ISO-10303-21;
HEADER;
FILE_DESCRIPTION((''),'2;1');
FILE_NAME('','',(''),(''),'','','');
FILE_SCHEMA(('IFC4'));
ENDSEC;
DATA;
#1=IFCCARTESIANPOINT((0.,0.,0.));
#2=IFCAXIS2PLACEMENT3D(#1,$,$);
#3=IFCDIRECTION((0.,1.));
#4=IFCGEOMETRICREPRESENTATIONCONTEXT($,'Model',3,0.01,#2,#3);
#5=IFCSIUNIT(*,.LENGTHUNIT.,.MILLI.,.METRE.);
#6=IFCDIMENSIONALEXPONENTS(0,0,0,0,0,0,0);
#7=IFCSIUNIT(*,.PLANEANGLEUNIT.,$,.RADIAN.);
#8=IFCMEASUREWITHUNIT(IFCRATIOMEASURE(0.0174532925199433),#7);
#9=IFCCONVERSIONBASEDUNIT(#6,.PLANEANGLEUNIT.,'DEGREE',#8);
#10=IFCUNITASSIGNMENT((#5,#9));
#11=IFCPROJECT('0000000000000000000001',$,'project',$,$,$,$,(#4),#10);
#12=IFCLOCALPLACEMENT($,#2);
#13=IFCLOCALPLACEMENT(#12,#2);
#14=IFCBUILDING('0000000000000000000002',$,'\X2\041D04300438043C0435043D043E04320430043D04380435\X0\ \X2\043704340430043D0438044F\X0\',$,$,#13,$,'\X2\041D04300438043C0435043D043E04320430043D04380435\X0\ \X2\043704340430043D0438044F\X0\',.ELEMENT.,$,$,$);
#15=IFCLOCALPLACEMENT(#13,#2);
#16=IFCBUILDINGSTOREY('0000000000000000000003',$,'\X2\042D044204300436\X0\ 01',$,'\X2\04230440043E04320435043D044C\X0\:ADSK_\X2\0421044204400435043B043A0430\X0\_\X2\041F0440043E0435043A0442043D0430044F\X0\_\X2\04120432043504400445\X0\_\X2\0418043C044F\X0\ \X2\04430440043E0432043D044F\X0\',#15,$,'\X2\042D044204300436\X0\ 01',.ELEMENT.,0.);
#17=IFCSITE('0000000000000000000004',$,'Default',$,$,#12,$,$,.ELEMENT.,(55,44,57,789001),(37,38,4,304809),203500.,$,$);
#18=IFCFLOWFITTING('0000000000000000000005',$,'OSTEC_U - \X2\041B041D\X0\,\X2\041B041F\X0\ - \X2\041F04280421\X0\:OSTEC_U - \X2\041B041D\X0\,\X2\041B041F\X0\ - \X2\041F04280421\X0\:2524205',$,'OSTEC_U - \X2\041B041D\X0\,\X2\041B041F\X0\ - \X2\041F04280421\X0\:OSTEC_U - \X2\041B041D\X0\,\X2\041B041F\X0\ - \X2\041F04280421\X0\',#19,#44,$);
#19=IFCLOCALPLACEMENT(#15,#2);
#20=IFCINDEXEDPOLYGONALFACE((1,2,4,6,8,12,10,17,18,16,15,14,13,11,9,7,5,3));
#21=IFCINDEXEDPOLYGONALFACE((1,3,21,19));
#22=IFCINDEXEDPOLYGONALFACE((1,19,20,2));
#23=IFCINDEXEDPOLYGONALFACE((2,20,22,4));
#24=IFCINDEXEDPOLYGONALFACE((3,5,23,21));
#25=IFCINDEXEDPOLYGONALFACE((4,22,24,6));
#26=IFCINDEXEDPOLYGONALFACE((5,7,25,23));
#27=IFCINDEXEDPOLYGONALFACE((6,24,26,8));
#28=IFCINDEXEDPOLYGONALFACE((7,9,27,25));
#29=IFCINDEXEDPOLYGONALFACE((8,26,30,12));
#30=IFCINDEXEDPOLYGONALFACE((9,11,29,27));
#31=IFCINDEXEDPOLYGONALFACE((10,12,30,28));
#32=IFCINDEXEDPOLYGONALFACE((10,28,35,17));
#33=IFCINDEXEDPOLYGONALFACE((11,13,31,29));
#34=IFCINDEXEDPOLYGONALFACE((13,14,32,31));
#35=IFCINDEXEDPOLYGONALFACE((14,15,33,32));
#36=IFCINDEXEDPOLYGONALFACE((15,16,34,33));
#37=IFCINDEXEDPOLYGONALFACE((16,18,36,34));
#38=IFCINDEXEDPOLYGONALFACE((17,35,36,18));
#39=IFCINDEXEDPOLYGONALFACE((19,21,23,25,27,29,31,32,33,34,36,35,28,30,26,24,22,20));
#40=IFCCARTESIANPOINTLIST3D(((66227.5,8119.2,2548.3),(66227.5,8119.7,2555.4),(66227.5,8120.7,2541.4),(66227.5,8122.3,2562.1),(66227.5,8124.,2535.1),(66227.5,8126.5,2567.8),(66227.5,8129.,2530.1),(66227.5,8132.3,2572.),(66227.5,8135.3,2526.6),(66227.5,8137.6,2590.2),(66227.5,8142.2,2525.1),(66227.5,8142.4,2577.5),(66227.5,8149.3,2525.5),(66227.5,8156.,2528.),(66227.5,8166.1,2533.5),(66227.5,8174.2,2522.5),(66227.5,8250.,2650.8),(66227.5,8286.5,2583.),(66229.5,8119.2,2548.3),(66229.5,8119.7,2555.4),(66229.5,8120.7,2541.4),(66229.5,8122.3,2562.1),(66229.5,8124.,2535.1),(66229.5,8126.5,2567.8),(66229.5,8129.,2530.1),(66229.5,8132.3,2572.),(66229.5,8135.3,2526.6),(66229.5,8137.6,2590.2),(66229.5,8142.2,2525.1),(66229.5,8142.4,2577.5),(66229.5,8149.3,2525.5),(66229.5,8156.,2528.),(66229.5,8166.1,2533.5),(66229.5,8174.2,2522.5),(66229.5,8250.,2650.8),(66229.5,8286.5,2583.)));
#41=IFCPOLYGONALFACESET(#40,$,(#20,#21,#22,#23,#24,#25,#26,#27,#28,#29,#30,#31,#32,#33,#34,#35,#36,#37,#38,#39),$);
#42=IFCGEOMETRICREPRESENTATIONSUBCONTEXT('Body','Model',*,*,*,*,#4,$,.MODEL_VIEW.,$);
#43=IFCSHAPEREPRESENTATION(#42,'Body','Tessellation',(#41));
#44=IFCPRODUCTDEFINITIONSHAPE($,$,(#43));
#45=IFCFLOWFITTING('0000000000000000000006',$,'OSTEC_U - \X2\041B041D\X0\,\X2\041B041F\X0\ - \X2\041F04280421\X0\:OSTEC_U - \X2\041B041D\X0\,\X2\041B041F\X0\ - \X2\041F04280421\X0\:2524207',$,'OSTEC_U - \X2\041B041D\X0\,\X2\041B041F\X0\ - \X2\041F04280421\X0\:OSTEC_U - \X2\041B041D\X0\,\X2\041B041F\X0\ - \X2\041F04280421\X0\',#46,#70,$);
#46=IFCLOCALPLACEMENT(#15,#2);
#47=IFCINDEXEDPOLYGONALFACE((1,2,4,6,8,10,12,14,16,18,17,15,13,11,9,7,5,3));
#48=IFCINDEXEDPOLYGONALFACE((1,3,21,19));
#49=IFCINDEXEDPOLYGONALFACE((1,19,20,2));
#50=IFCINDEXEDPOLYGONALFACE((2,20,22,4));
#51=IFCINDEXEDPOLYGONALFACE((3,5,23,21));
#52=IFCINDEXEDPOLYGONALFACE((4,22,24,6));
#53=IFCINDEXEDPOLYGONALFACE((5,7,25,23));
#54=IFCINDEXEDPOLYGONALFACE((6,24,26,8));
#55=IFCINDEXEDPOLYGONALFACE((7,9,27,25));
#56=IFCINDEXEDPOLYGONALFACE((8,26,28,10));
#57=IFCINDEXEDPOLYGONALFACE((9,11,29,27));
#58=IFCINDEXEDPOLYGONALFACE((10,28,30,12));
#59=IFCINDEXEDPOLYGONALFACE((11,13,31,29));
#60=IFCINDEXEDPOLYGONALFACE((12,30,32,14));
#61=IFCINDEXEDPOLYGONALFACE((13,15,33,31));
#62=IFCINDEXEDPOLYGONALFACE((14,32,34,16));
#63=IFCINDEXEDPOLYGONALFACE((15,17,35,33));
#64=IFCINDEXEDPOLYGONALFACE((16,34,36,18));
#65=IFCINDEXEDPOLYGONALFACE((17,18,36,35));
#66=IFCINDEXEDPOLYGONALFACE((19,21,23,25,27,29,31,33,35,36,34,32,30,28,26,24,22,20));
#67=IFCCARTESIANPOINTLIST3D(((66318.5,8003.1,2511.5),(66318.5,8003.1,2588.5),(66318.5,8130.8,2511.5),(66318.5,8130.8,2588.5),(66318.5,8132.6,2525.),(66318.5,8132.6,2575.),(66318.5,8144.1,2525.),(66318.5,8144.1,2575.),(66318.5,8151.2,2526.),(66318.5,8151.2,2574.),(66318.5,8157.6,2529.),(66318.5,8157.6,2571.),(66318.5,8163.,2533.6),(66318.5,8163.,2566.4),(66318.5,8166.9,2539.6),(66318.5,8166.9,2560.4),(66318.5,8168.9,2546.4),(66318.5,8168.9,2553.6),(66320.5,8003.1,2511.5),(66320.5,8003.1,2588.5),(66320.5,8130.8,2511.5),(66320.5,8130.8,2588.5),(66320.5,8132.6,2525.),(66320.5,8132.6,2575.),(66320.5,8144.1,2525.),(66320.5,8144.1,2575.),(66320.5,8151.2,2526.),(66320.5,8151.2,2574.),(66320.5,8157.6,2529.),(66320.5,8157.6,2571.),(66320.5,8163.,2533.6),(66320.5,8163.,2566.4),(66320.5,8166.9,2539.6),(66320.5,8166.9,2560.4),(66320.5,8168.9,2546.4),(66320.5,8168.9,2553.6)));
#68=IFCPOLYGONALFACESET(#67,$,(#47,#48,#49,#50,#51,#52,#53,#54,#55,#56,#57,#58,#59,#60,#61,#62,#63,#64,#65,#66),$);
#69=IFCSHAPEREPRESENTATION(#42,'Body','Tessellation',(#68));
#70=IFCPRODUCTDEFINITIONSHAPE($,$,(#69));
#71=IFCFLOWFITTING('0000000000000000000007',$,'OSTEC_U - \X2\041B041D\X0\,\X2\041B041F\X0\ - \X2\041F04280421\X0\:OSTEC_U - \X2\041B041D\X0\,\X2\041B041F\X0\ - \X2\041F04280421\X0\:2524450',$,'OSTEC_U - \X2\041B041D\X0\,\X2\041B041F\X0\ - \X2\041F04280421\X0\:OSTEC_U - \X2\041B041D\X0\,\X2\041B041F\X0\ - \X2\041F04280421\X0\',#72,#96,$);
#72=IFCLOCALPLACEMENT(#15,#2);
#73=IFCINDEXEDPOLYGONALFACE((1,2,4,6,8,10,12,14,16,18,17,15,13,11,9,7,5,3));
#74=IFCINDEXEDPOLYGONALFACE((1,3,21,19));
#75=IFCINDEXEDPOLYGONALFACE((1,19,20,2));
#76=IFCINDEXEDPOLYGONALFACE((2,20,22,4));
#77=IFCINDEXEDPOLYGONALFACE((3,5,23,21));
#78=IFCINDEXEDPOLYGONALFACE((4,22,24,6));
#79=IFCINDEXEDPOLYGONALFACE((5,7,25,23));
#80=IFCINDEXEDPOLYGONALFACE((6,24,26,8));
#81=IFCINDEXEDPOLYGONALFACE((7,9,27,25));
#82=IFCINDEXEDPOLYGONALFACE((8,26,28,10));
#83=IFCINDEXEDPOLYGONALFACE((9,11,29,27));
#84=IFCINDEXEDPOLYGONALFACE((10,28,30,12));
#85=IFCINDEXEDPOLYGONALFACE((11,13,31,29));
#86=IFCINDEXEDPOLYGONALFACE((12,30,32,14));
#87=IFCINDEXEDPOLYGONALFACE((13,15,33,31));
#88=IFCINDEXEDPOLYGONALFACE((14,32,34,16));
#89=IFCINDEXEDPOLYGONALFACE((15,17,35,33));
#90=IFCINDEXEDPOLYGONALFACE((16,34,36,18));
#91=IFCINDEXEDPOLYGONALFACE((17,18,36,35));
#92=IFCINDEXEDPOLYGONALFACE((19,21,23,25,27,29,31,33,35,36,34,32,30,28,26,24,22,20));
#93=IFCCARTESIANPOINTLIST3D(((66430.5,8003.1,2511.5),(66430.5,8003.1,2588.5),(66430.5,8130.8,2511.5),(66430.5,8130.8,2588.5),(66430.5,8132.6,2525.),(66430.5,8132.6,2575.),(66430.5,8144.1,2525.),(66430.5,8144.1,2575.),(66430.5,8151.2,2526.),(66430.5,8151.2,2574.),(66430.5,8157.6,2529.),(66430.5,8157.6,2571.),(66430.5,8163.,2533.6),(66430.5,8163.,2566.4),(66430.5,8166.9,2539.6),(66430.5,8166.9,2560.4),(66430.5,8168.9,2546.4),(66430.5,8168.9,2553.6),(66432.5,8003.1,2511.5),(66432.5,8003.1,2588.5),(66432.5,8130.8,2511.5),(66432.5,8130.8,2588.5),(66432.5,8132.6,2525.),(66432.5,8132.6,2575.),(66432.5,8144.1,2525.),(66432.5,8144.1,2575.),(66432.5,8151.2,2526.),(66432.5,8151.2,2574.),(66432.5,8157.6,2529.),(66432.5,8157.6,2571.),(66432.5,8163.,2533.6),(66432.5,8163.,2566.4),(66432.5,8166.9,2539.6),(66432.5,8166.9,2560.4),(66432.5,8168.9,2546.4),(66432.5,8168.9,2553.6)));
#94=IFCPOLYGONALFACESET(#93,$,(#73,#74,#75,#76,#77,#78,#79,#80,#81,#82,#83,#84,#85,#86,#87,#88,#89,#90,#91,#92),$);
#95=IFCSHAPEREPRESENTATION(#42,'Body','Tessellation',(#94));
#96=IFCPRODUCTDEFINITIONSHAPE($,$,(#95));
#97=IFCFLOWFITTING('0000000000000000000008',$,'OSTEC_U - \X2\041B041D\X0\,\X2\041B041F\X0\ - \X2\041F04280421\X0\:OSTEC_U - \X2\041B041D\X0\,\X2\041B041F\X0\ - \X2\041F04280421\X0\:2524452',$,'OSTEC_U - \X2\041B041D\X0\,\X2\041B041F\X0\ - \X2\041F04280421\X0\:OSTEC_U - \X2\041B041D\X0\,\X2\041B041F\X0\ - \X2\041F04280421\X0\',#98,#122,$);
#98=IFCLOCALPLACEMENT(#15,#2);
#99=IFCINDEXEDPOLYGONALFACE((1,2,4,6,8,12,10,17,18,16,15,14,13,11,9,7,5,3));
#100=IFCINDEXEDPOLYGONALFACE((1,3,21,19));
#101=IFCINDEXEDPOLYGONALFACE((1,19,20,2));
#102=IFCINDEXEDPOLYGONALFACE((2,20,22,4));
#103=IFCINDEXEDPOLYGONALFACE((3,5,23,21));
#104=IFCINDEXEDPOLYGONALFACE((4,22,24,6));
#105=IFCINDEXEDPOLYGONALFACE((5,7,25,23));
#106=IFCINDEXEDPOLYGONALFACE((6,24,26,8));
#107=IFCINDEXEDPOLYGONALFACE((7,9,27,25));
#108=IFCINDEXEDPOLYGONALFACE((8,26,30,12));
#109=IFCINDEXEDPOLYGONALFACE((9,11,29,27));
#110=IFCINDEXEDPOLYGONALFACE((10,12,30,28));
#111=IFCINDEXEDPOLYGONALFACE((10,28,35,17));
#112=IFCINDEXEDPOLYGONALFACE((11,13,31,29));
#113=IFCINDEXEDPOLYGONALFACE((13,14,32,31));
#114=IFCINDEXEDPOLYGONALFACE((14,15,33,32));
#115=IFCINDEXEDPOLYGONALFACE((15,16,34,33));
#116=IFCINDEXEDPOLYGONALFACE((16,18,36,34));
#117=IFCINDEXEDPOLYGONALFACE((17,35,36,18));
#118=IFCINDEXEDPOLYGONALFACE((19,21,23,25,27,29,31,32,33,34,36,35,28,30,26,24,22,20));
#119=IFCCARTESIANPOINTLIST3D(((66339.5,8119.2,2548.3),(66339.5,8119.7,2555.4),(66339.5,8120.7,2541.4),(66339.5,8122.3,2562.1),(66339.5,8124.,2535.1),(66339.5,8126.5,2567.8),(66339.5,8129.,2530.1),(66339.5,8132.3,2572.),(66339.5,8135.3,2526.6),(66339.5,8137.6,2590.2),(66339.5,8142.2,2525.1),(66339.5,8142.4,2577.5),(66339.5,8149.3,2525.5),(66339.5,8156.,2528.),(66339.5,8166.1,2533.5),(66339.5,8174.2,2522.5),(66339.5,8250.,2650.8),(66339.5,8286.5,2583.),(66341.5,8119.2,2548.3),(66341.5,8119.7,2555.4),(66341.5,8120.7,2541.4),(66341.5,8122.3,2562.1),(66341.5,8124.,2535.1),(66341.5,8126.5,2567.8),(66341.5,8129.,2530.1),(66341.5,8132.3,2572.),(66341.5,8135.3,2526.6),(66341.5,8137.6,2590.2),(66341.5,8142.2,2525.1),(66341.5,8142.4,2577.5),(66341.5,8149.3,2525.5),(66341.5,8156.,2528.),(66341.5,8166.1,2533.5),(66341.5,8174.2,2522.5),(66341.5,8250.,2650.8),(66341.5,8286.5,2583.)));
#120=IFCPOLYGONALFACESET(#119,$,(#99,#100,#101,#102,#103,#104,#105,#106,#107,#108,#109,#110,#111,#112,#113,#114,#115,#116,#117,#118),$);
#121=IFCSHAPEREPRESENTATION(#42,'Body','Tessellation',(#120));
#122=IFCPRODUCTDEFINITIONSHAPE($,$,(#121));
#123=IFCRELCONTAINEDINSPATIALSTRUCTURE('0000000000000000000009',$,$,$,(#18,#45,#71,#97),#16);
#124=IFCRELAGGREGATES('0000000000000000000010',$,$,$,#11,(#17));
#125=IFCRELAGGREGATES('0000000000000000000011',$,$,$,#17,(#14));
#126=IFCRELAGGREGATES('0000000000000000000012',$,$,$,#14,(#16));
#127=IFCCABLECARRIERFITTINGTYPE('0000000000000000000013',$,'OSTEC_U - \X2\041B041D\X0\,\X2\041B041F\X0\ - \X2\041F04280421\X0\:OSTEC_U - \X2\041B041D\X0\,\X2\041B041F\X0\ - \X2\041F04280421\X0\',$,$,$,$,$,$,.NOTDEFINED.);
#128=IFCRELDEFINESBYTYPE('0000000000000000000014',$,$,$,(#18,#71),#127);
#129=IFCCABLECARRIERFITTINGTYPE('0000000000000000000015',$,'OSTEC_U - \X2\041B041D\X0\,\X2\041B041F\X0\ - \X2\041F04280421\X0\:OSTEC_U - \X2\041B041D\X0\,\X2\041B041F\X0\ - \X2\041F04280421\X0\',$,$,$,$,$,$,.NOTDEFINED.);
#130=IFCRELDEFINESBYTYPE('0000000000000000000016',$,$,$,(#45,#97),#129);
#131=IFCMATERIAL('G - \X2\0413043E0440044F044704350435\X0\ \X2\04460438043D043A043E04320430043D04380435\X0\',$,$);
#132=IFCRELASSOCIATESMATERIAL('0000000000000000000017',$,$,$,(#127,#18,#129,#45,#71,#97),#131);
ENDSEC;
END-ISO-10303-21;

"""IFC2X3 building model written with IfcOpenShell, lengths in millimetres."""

from ifc_helpers import new_model, entity, si_unit, converted_unit, direction, frame, frame_2d, origin, place, context, subcontext, project, spatial, polyline, circle_curve, parameter, trimmed, segment, composite_curve, outline, extrude, source, transform, mapped, material, type_object, type_shapes, element, save


model = new_model("IFC2X3")

# Units and contexts
model_context = context("Model", 3, precision=0.01, world=origin(), true_north=direction((0.0, 1.0)))
body_context = subcontext(model_context, "Body", "Model", "MODEL_VIEW")
ifc_project = project(units=[si_unit("LENGTHUNIT", "METRE", prefix="MILLI"), converted_unit("PLANEANGLEUNIT", "DEGREE", entity("IfcRatioMeasure", 0.0174532925199433), si_unit("PLANEANGLEUNIT", "RADIAN"), dimensions=[0, 0, 0, 0, 0, 0, 0])], contexts=[model_context])

# Site, building, storey
site_placement = place(None, origin())
site = spatial("IfcSite", under=ifc_project, at=site_placement, Name="Default", CompositionType="ELEMENT", RefLatitude=(55, 44, 57, 789001), RefLongitude=(37, 38, 4, 304809), RefElevation=203500.0)
building_placement = place(site_placement, origin())
building = spatial("IfcBuilding", under=site, at=building_placement, Name="Наименование здания", LongName="Наименование здания", CompositionType="ELEMENT")
storey_placement = place(building_placement, origin())
storey = spatial("IfcBuildingStorey", under=building, at=storey_placement, Name="Этаж 01", ObjectType="Уровень:ADSK_Стрелка_Проектная_Вверх_Имя уровня", LongName="Этаж 01", CompositionType="ELEMENT", Elevation=0.0)

# Flow fittings
ifc_material = material(Name="G - Горячее цинкование")
cable_carrier_fitting_type_1 = type_object("IfcCableCarrierFittingType", Name="OSTEC_U - ЛН,ЛП - ПШС:OSTEC_U - ЛН,ЛП - ПШС", PredefinedType="NOTDEFINED", material=ifc_material)
shared_shape_1 = source(origin(), body_context, "Body", "SweptSolid", [
    extrude(outline(composite_curve([segment(trimmed(circle_curve(frame_2d((-41.5, 0.0), x_axis=(1.0, 0.0)), 25.0), [parameter(90.0)], [parameter(270.0)], True, "PARAMETER"), True, "CONTINUOUS"), segment(polyline([(-41.5, -25.0), (-30.0, -25.0)]), True, "CONTINUOUS"), segment(polyline([(-30.0, -25.0), (-28.1, -38.5)]), True, "CONTINUOUS"), segment(polyline([(-28.1, -38.5), (99.5, -38.5)]), True, "CONTINUOUS"), segment(polyline([(99.5, -38.5), (99.5, 38.5)]), True, "CONTINUOUS"), segment(polyline([(99.5, 38.5), (-28.1, 38.5)]), True, "CONTINUOUS"), segment(polyline([(-28.1, 38.5), (-30.0, 25.0)]), True, "CONTINUOUS"), segment(polyline([(-30.0, 25.0), (-41.5, 25.0)]), True, "CONTINUOUS")], self_intersect=False)), frame((41.5, 0.0, 0.0)), (0.0, 0.0, 1.0), 2.0),
])
type_shapes(cable_carrier_fitting_type_1, [shared_shape_1])
for number, where, z_axis, x_axis, name in (
    (1, (66229.5, 8144.1, 2550.0), (-1.0, 0.0, 0.0), (0.0, 0.880203, 0.474598), "OSTEC_U - ЛН,ЛП - ПШС:OSTEC_U - ЛН,ЛП - ПШС:2524205"),
):
    element("IfcFlowFitting", number, at=place(storey_placement, frame(where, z_axis=z_axis, x_axis=x_axis)), inside=storey, type_object=cable_carrier_fitting_type_1, material=ifc_material, Name=name, ObjectType="OSTEC_U - ЛН,ЛП - ПШС:OSTEC_U - ЛН,ЛП - ПШС", context=body_context, shape_type="MappedRepresentation", body=[
        mapped(shared_shape_1, transform((0.0, 0.0, 0.0), scale=1.0)),
    ])
cable_carrier_fitting_type_2 = type_object("IfcCableCarrierFittingType", Name="OSTEC_U - ЛН,ЛП - ПШС:OSTEC_U - ЛН,ЛП - ПШС", PredefinedType="NOTDEFINED", material=ifc_material)
type_shapes(cable_carrier_fitting_type_2, [shared_shape_1])
flow_fitting_1_placement = place(storey_placement, frame((66318.5, 8144.1, 2550.0), z_axis=(1.0, 0.0, 0.0), x_axis=(0.0, -1.0, 0.0)))
element("IfcFlowFitting", 2, at=flow_fitting_1_placement, inside=storey, type_object=cable_carrier_fitting_type_2, material=ifc_material, Name="OSTEC_U - ЛН,ЛП - ПШС:OSTEC_U - ЛН,ЛП - ПШС:2524207", ObjectType="OSTEC_U - ЛН,ЛП - ПШС:OSTEC_U - ЛН,ЛП - ПШС", context=body_context, shape_type="MappedRepresentation", body=[
    mapped(shared_shape_1, transform((0.0, 0.0, 0.0), scale=1.0)),
])
flow_fitting_2_placement = place(storey_placement, frame((66430.5, 8144.1, 2550.0), z_axis=(1.0, 0.0, 0.0), x_axis=(0.0, -1.0, 0.0)))
element("IfcFlowFitting", 3, at=flow_fitting_2_placement, inside=storey, type_object=cable_carrier_fitting_type_1, material=ifc_material, Name="OSTEC_U - ЛН,ЛП - ПШС:OSTEC_U - ЛН,ЛП - ПШС:2524450", ObjectType="OSTEC_U - ЛН,ЛП - ПШС:OSTEC_U - ЛН,ЛП - ПШС", context=body_context, shape_type="MappedRepresentation", body=[
    mapped(shared_shape_1, transform((0.0, 0.0, 0.0), scale=1.0)),
])
flow_fitting_3_placement = place(storey_placement, frame((66341.5, 8144.1, 2550.0), z_axis=(-1.0, 0.0, 0.0), x_axis=(0.0, 0.880203, 0.474598)))
element("IfcFlowFitting", 4, at=flow_fitting_3_placement, inside=storey, type_object=cable_carrier_fitting_type_2, material=ifc_material, Name="OSTEC_U - ЛН,ЛП - ПШС:OSTEC_U - ЛН,ЛП - ПШС:2524452", ObjectType="OSTEC_U - ЛН,ЛП - ПШС:OSTEC_U - ЛН,ЛП - ПШС", context=body_context, shape_type="MappedRepresentation", body=[
    mapped(shared_shape_1, transform((0.0, 0.0, 0.0), scale=1.0)),
])

save(model, "model.ifc")
